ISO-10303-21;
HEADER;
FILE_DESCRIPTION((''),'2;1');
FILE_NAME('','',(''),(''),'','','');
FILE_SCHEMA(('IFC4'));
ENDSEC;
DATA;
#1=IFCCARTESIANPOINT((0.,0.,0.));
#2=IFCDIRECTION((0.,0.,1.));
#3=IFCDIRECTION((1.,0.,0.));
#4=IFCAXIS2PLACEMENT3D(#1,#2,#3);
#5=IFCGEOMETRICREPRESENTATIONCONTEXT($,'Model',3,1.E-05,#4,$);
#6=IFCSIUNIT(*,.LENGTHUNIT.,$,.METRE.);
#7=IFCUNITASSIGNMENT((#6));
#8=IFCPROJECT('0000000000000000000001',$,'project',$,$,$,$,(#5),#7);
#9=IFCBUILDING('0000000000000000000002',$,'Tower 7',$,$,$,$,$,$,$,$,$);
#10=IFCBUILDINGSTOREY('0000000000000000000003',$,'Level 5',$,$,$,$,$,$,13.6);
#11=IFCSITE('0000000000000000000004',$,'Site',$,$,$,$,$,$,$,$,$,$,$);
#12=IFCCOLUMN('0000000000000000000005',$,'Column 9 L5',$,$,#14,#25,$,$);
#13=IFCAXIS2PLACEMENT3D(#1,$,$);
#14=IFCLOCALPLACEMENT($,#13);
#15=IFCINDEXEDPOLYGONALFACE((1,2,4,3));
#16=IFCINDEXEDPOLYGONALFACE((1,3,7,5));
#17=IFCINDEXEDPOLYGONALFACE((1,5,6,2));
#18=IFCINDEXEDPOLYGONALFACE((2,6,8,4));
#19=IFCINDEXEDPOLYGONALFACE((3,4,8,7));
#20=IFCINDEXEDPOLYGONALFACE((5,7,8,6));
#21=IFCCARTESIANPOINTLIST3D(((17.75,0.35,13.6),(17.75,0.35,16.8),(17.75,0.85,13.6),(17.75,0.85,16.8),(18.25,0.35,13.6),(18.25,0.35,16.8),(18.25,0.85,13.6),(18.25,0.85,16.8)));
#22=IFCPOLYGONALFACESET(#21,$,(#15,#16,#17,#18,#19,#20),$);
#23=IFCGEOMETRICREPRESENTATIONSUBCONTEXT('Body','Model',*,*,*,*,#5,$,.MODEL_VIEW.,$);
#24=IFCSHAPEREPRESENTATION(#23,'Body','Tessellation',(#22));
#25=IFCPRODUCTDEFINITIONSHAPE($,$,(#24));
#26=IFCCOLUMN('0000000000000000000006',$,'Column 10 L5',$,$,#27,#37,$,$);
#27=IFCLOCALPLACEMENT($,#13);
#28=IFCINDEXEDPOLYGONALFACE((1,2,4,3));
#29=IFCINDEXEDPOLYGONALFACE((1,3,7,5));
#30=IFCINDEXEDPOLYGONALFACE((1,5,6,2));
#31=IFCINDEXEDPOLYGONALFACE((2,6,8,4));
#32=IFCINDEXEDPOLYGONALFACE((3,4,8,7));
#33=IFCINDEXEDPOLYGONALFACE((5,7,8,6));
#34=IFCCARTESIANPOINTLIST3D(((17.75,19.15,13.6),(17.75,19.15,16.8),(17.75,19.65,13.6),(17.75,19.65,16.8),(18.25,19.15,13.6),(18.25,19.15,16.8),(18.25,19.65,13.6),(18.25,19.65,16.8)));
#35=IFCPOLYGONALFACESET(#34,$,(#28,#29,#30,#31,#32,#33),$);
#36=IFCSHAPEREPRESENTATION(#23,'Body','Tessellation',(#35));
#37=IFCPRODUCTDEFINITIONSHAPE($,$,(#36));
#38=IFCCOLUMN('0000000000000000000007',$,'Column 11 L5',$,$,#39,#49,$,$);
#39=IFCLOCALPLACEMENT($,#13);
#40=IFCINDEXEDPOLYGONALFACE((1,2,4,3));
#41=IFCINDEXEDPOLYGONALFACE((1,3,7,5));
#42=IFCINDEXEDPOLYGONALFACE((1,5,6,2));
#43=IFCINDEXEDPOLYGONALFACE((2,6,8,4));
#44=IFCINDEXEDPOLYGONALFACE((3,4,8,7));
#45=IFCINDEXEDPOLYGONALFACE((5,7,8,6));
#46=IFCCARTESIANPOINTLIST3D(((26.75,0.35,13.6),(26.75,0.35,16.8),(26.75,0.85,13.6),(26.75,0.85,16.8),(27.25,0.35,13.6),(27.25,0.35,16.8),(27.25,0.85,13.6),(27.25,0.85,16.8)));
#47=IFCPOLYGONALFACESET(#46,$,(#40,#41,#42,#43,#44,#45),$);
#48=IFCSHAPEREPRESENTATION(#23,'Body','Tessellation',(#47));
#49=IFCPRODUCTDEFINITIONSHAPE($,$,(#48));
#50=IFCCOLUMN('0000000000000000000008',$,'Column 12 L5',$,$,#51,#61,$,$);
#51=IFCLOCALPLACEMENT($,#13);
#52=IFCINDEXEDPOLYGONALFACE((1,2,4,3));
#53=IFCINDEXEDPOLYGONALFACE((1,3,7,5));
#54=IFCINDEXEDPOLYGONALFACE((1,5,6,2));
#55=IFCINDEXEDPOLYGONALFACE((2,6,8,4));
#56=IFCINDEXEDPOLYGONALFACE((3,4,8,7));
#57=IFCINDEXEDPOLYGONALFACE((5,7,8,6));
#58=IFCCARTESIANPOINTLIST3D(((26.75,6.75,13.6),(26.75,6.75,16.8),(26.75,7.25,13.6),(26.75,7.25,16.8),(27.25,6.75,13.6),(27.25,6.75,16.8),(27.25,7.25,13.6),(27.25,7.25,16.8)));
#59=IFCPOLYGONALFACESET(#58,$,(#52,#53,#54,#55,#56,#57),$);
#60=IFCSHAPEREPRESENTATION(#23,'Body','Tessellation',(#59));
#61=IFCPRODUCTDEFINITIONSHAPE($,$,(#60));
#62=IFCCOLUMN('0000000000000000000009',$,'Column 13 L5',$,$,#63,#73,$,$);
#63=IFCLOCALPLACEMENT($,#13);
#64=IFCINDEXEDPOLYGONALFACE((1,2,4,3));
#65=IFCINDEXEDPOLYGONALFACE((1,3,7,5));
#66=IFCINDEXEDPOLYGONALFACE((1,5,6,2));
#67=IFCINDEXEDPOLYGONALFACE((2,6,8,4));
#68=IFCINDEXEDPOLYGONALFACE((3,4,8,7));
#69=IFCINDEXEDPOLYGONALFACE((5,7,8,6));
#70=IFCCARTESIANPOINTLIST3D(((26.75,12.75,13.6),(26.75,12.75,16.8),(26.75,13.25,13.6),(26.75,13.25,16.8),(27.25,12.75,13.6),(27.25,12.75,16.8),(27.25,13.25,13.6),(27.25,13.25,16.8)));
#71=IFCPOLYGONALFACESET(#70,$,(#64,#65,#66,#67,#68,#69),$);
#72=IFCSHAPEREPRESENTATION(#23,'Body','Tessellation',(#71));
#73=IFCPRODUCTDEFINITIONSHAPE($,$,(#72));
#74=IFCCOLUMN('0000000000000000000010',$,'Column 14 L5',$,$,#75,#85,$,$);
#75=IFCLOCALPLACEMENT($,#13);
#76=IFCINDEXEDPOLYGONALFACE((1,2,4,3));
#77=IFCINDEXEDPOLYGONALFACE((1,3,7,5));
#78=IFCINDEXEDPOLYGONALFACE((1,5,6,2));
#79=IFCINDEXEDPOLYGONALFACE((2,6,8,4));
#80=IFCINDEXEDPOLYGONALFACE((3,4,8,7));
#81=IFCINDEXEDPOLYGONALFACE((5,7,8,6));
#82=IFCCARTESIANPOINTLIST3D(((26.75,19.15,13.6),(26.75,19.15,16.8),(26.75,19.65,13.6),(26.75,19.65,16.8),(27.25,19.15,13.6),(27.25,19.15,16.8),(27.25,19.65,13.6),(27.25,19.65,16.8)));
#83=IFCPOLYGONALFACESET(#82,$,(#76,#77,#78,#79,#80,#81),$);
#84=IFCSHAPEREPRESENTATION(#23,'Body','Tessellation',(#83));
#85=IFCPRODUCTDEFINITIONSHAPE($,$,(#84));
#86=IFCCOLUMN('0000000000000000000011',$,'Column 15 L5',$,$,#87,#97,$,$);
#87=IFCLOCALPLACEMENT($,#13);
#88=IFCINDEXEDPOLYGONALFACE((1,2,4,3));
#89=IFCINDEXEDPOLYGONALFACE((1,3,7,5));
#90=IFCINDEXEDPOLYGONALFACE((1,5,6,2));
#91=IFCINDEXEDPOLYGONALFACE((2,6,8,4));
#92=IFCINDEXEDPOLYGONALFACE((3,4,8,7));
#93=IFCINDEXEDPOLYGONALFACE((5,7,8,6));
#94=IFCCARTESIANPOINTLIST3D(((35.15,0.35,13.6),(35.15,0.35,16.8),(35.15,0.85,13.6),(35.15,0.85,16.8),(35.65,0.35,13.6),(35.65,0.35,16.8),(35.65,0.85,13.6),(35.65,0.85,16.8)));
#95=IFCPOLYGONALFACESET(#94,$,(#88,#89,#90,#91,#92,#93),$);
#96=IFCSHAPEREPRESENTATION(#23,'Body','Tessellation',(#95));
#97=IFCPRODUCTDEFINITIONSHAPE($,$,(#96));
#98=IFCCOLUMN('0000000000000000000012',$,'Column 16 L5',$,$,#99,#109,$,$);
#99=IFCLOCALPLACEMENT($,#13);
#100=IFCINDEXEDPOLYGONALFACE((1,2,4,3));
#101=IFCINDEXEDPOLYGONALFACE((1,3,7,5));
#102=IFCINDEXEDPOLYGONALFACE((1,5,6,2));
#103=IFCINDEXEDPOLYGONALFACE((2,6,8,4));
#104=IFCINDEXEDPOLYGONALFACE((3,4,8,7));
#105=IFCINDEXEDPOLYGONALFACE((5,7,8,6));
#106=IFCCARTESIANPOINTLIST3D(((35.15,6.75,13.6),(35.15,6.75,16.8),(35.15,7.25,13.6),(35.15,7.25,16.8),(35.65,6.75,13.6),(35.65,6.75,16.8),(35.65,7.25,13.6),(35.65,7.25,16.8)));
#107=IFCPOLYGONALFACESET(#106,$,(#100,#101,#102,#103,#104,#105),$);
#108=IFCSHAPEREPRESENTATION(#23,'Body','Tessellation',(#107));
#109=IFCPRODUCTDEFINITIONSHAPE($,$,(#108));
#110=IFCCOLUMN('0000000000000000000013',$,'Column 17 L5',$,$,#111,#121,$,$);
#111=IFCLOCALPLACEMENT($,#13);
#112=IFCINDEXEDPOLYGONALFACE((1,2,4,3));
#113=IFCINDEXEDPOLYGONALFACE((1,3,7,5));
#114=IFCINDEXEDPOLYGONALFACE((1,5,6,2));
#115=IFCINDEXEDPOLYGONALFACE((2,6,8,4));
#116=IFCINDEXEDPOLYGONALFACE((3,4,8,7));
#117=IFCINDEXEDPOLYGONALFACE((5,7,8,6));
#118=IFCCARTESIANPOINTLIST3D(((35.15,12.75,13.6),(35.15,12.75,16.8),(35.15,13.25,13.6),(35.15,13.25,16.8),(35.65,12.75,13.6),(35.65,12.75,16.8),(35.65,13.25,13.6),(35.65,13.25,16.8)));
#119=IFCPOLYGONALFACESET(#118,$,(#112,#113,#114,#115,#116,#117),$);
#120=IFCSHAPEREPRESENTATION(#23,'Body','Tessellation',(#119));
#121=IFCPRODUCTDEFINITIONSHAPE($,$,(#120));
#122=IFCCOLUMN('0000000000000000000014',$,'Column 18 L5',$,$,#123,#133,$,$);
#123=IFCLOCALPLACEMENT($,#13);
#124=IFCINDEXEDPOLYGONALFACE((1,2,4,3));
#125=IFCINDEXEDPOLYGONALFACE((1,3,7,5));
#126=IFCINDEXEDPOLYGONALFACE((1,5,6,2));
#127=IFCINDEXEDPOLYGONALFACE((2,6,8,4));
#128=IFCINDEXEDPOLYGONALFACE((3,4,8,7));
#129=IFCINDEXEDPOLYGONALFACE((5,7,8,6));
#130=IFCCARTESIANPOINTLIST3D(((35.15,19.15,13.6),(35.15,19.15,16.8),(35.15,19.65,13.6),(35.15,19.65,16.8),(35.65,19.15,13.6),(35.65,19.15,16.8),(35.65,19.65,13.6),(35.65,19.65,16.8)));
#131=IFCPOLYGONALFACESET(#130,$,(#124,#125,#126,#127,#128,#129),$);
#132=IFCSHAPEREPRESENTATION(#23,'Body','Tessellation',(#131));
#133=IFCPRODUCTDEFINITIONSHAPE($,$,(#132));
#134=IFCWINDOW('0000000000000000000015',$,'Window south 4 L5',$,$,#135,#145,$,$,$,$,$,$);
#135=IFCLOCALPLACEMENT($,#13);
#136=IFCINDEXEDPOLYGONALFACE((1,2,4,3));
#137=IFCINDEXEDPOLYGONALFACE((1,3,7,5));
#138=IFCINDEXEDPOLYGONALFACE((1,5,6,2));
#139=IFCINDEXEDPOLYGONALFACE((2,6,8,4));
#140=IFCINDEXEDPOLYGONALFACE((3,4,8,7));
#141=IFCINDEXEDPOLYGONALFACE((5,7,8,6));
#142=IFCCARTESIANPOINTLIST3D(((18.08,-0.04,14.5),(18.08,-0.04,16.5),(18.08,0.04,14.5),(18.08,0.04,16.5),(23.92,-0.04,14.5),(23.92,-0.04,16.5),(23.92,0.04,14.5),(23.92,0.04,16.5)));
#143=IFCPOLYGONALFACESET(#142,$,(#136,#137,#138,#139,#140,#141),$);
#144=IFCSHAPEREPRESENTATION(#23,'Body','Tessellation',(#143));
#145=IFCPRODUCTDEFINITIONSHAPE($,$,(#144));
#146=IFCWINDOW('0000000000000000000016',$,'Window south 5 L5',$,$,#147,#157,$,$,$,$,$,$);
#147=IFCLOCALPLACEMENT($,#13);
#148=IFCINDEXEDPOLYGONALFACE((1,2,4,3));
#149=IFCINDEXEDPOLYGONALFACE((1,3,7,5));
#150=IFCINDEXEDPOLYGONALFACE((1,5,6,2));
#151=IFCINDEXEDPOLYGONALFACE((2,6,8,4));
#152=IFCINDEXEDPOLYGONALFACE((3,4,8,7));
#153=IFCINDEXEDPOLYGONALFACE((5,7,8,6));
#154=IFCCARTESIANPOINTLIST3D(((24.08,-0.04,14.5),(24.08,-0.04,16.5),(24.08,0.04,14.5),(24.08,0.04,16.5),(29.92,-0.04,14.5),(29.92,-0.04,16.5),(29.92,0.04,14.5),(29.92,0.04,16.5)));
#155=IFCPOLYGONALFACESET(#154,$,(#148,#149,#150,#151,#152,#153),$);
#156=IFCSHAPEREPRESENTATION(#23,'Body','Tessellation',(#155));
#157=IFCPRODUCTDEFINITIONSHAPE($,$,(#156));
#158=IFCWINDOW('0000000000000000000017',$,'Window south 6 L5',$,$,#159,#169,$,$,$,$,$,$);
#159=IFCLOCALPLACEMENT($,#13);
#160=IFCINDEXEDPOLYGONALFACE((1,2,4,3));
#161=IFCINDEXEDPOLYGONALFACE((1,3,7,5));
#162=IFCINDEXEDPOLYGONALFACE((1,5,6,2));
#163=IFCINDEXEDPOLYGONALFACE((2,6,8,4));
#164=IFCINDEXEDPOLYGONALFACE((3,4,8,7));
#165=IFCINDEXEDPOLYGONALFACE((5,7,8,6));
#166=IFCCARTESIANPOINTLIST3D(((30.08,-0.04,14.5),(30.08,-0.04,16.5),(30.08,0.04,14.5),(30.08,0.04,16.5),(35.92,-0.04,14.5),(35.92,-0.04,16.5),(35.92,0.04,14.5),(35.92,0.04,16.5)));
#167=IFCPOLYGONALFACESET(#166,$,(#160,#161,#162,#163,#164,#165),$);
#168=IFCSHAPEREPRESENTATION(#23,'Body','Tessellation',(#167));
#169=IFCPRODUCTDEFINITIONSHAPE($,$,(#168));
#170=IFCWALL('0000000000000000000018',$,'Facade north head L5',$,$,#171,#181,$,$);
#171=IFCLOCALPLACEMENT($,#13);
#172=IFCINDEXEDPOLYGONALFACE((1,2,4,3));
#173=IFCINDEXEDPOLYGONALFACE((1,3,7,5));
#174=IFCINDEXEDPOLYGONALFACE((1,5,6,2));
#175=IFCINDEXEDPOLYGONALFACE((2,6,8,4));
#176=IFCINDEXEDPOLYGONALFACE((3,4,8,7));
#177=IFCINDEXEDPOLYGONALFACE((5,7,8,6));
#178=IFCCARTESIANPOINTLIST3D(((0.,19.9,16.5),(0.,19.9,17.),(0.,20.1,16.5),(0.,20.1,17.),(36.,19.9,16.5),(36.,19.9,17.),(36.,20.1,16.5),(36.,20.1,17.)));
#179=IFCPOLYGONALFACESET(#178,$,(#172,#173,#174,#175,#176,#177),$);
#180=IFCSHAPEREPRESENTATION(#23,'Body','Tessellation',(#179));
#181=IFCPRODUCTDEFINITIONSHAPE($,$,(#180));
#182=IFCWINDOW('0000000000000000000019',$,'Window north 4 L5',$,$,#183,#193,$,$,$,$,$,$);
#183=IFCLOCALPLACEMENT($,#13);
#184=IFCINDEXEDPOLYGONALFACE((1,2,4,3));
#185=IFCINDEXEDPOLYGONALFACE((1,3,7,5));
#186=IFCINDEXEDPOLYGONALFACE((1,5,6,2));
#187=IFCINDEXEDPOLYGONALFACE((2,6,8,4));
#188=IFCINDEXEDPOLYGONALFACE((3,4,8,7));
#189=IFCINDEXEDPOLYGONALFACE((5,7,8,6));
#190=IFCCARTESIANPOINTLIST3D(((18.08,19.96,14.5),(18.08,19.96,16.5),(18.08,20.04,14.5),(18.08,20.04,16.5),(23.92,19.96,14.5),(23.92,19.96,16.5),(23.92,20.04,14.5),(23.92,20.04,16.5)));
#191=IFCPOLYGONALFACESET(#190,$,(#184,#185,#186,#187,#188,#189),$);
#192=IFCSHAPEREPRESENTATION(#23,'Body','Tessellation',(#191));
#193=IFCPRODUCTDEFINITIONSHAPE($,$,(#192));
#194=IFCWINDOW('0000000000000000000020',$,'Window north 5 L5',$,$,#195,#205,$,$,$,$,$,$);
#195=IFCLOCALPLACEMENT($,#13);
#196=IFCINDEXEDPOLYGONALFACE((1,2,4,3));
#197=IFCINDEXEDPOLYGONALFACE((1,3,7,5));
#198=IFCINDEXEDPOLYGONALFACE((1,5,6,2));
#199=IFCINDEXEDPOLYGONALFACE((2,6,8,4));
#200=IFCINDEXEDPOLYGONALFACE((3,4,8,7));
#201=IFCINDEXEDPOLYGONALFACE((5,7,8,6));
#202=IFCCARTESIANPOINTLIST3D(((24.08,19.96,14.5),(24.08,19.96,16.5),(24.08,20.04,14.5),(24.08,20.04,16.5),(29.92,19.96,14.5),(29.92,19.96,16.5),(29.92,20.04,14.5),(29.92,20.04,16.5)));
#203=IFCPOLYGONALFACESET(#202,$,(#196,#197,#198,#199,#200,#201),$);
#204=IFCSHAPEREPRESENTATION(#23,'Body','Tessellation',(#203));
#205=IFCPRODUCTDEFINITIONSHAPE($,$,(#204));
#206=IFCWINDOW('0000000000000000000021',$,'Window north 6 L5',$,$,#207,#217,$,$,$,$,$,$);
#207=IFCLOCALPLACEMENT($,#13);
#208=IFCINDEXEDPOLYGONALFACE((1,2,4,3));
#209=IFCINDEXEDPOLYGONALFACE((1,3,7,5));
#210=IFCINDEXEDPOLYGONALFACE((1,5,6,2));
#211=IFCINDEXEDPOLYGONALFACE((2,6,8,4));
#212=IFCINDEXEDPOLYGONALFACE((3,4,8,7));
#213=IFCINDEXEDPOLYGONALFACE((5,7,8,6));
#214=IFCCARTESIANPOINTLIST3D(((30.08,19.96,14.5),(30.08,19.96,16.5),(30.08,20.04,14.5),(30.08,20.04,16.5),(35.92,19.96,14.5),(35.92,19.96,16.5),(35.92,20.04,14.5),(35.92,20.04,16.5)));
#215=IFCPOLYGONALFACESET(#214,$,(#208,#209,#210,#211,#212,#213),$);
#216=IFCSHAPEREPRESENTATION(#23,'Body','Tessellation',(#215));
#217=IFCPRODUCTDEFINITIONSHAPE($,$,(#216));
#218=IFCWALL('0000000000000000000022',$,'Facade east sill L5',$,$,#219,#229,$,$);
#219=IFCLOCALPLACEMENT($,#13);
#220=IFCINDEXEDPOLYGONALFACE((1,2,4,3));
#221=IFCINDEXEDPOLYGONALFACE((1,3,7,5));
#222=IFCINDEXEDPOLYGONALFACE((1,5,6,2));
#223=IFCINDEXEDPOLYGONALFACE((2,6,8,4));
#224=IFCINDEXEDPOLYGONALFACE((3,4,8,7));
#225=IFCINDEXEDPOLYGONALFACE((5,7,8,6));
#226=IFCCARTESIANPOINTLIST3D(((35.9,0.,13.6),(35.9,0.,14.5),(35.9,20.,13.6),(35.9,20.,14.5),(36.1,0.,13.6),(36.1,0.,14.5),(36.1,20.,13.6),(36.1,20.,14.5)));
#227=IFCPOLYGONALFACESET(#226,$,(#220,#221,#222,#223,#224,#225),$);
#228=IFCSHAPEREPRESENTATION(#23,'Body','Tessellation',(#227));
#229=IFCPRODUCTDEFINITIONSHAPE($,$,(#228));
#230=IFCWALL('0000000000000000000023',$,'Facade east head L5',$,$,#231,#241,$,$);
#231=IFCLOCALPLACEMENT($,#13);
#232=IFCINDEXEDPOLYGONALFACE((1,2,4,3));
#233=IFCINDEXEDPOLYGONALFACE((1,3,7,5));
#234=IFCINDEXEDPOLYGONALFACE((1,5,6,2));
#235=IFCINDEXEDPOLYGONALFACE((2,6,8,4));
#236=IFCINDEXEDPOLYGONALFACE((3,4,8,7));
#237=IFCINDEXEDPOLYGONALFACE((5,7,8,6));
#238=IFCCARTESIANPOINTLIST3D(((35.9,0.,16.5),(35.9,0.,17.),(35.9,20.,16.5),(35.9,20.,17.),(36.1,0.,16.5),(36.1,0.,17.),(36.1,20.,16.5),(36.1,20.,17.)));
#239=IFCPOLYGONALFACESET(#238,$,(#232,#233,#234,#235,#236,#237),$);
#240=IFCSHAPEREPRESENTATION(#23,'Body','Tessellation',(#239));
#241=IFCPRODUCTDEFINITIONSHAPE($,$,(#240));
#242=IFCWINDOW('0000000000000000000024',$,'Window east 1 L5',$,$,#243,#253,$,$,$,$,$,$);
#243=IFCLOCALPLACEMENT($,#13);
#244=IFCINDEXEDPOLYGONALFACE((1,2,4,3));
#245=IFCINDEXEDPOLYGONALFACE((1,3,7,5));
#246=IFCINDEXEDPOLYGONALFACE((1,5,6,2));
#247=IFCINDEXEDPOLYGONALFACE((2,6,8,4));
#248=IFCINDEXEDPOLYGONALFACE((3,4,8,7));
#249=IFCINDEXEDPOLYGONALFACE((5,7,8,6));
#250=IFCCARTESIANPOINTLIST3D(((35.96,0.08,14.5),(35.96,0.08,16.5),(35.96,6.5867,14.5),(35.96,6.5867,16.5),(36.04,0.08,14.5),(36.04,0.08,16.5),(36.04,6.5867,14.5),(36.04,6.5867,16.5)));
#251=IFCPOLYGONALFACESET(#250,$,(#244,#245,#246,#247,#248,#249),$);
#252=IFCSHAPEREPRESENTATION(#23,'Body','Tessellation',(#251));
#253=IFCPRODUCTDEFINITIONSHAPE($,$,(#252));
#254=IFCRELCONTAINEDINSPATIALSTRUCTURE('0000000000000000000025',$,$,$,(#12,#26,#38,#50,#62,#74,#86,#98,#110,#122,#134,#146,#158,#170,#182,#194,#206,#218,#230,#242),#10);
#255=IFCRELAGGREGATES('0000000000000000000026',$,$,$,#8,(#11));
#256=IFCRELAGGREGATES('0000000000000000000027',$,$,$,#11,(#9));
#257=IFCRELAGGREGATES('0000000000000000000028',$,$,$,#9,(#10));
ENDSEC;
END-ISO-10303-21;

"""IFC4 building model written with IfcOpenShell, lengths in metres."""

from ifc_helpers import new_model, si_unit, frame, origin, origin_with_axes, origin_2d, place, context, subcontext, project, spatial, rectangle, extrude, element, save


model = new_model("IFC4")

# Units and contexts
model_context = context("Model", 3, precision=1e-05, world=origin_with_axes())
body_context = subcontext(model_context, "Body", "Model", "MODEL_VIEW")
ifc_project = project(units=[si_unit("LENGTHUNIT", "METRE")], contexts=[model_context])

# Site, building, storey
site = spatial("IfcSite", under=ifc_project, Name="Site")
building = spatial("IfcBuilding", under=site, Name="Tower 7")
storey = spatial("IfcBuildingStorey", under=building, Name="Level 5", Elevation=13.6)

# Columns
for number, where, z_axis, x_axis, name in (
    (1, (18.0, 0.6, 13.6), (0.0, 0.0, 1.0), (1.0, 0.0, 0.0), "Column 9 L5"),
    (2, (18.0, 19.4, 13.6), (0.0, 0.0, 1.0), (1.0, 0.0, 0.0), "Column 10 L5"),
    (3, (27.0, 0.6, 13.6), (0.0, 0.0, 1.0), (1.0, 0.0, 0.0), "Column 11 L5"),
    (4, (27.0, 7.0, 13.6), (0.0, 0.0, 1.0), (1.0, 0.0, 0.0), "Column 12 L5"),
    (5, (27.0, 13.0, 13.6), (0.0, 0.0, 1.0), (1.0, 0.0, 0.0), "Column 13 L5"),
    (6, (27.0, 19.4, 13.6), (0.0, 0.0, 1.0), (1.0, 0.0, 0.0), "Column 14 L5"),
    (7, (35.4, 0.6, 13.6), (0.0, 0.0, 1.0), (1.0, 0.0, 0.0), "Column 15 L5"),
    (8, (35.4, 7.0, 13.6), (0.0, 0.0, 1.0), (1.0, 0.0, 0.0), "Column 16 L5"),
    (9, (35.4, 13.0, 13.6), (0.0, 0.0, 1.0), (1.0, 0.0, 0.0), "Column 17 L5"),
    (10, (35.4, 19.4, 13.6), (0.0, 0.0, 1.0), (1.0, 0.0, 0.0), "Column 18 L5"),
):
    element("IfcColumn", number, at=place(None, frame(where, z_axis=z_axis, x_axis=x_axis)), inside=storey, Name=name, context=body_context, shape_type="SweptSolid", body=[
        extrude(rectangle(XDim=0.5, YDim=0.5, at=origin_2d()), origin(), (0.0, 0.0, 1.0), 3.2),
    ])

# Windows
for number, where, z_axis, x_axis, name in (
    (11, (21.0, 0.0, 14.5), (0.0, 0.0, 1.0), (1.0, 0.0, 0.0), "Window south 4 L5"),
    (12, (27.0, 0.0, 14.5), (0.0, 0.0, 1.0), (1.0, 0.0, 0.0), "Window south 5 L5"),
    (13, (33.0, 0.0, 14.5), (0.0, 0.0, 1.0), (1.0, 0.0, 0.0), "Window south 6 L5"),
):
    element("IfcWindow", number, at=place(None, frame(where, z_axis=z_axis, x_axis=x_axis)), inside=storey, Name=name, context=body_context, shape_type="SweptSolid", body=[
        extrude(rectangle(XDim=5.84, YDim=0.08, at=origin_2d()), origin(), (0.0, 0.0, 1.0), 2.0),
    ])

# Wall
wall_1_placement = place(None, frame((18.0, 20.0, 16.5), z_axis=(0.0, 0.0, 1.0), x_axis=(1.0, 0.0, 0.0)))
element("IfcWall", 14, at=wall_1_placement, inside=storey, Name="Facade north head L5", context=body_context, shape_type="SweptSolid", body=[
    extrude(rectangle(XDim=36.0, YDim=0.2, at=origin_2d()), origin(), (0.0, 0.0, 1.0), 0.5),
])

# Windows
for number, where, z_axis, x_axis, name in (
    (15, (21.0, 20.0, 14.5), (0.0, 0.0, 1.0), (1.0, 0.0, 0.0), "Window north 4 L5"),
    (16, (27.0, 20.0, 14.5), (0.0, 0.0, 1.0), (1.0, 0.0, 0.0), "Window north 5 L5"),
    (17, (33.0, 20.0, 14.5), (0.0, 0.0, 1.0), (1.0, 0.0, 0.0), "Window north 6 L5"),
):
    element("IfcWindow", number, at=place(None, frame(where, z_axis=z_axis, x_axis=x_axis)), inside=storey, Name=name, context=body_context, shape_type="SweptSolid", body=[
        extrude(rectangle(XDim=5.84, YDim=0.08, at=origin_2d()), origin(), (0.0, 0.0, 1.0), 2.0),
    ])

# Walls
wall_2_placement = place(None, frame((36.0, 10.0, 13.6), z_axis=(0.0, 0.0, 1.0), x_axis=(1.0, 0.0, 0.0)))
element("IfcWall", 18, at=wall_2_placement, inside=storey, Name="Facade east sill L5", context=body_context, shape_type="SweptSolid", body=[
    extrude(rectangle(XDim=0.2, YDim=20.0, at=origin_2d()), origin(), (0.0, 0.0, 1.0), 0.9),
])
wall_3_placement = place(None, frame((36.0, 10.0, 16.5), z_axis=(0.0, 0.0, 1.0), x_axis=(1.0, 0.0, 0.0)))
element("IfcWall", 19, at=wall_3_placement, inside=storey, Name="Facade east head L5", context=body_context, shape_type="SweptSolid", body=[
    extrude(rectangle(XDim=0.2, YDim=20.0, at=origin_2d()), origin(), (0.0, 0.0, 1.0), 0.5),
])

# Window
for number, where, z_axis, x_axis, name in (
    (20, (36.0, 3.3333, 14.5), (0.0, 0.0, 1.0), (1.0, 0.0, 0.0), "Window east 1 L5"),
):
    element("IfcWindow", number, at=place(None, frame(where, z_axis=z_axis, x_axis=x_axis)), inside=storey, Name=name, context=body_context, shape_type="SweptSolid", body=[
        extrude(rectangle(XDim=0.08, YDim=6.5067, at=origin_2d()), origin(), (0.0, 0.0, 1.0), 2.0),
    ])

save(model, "model.ifc")
